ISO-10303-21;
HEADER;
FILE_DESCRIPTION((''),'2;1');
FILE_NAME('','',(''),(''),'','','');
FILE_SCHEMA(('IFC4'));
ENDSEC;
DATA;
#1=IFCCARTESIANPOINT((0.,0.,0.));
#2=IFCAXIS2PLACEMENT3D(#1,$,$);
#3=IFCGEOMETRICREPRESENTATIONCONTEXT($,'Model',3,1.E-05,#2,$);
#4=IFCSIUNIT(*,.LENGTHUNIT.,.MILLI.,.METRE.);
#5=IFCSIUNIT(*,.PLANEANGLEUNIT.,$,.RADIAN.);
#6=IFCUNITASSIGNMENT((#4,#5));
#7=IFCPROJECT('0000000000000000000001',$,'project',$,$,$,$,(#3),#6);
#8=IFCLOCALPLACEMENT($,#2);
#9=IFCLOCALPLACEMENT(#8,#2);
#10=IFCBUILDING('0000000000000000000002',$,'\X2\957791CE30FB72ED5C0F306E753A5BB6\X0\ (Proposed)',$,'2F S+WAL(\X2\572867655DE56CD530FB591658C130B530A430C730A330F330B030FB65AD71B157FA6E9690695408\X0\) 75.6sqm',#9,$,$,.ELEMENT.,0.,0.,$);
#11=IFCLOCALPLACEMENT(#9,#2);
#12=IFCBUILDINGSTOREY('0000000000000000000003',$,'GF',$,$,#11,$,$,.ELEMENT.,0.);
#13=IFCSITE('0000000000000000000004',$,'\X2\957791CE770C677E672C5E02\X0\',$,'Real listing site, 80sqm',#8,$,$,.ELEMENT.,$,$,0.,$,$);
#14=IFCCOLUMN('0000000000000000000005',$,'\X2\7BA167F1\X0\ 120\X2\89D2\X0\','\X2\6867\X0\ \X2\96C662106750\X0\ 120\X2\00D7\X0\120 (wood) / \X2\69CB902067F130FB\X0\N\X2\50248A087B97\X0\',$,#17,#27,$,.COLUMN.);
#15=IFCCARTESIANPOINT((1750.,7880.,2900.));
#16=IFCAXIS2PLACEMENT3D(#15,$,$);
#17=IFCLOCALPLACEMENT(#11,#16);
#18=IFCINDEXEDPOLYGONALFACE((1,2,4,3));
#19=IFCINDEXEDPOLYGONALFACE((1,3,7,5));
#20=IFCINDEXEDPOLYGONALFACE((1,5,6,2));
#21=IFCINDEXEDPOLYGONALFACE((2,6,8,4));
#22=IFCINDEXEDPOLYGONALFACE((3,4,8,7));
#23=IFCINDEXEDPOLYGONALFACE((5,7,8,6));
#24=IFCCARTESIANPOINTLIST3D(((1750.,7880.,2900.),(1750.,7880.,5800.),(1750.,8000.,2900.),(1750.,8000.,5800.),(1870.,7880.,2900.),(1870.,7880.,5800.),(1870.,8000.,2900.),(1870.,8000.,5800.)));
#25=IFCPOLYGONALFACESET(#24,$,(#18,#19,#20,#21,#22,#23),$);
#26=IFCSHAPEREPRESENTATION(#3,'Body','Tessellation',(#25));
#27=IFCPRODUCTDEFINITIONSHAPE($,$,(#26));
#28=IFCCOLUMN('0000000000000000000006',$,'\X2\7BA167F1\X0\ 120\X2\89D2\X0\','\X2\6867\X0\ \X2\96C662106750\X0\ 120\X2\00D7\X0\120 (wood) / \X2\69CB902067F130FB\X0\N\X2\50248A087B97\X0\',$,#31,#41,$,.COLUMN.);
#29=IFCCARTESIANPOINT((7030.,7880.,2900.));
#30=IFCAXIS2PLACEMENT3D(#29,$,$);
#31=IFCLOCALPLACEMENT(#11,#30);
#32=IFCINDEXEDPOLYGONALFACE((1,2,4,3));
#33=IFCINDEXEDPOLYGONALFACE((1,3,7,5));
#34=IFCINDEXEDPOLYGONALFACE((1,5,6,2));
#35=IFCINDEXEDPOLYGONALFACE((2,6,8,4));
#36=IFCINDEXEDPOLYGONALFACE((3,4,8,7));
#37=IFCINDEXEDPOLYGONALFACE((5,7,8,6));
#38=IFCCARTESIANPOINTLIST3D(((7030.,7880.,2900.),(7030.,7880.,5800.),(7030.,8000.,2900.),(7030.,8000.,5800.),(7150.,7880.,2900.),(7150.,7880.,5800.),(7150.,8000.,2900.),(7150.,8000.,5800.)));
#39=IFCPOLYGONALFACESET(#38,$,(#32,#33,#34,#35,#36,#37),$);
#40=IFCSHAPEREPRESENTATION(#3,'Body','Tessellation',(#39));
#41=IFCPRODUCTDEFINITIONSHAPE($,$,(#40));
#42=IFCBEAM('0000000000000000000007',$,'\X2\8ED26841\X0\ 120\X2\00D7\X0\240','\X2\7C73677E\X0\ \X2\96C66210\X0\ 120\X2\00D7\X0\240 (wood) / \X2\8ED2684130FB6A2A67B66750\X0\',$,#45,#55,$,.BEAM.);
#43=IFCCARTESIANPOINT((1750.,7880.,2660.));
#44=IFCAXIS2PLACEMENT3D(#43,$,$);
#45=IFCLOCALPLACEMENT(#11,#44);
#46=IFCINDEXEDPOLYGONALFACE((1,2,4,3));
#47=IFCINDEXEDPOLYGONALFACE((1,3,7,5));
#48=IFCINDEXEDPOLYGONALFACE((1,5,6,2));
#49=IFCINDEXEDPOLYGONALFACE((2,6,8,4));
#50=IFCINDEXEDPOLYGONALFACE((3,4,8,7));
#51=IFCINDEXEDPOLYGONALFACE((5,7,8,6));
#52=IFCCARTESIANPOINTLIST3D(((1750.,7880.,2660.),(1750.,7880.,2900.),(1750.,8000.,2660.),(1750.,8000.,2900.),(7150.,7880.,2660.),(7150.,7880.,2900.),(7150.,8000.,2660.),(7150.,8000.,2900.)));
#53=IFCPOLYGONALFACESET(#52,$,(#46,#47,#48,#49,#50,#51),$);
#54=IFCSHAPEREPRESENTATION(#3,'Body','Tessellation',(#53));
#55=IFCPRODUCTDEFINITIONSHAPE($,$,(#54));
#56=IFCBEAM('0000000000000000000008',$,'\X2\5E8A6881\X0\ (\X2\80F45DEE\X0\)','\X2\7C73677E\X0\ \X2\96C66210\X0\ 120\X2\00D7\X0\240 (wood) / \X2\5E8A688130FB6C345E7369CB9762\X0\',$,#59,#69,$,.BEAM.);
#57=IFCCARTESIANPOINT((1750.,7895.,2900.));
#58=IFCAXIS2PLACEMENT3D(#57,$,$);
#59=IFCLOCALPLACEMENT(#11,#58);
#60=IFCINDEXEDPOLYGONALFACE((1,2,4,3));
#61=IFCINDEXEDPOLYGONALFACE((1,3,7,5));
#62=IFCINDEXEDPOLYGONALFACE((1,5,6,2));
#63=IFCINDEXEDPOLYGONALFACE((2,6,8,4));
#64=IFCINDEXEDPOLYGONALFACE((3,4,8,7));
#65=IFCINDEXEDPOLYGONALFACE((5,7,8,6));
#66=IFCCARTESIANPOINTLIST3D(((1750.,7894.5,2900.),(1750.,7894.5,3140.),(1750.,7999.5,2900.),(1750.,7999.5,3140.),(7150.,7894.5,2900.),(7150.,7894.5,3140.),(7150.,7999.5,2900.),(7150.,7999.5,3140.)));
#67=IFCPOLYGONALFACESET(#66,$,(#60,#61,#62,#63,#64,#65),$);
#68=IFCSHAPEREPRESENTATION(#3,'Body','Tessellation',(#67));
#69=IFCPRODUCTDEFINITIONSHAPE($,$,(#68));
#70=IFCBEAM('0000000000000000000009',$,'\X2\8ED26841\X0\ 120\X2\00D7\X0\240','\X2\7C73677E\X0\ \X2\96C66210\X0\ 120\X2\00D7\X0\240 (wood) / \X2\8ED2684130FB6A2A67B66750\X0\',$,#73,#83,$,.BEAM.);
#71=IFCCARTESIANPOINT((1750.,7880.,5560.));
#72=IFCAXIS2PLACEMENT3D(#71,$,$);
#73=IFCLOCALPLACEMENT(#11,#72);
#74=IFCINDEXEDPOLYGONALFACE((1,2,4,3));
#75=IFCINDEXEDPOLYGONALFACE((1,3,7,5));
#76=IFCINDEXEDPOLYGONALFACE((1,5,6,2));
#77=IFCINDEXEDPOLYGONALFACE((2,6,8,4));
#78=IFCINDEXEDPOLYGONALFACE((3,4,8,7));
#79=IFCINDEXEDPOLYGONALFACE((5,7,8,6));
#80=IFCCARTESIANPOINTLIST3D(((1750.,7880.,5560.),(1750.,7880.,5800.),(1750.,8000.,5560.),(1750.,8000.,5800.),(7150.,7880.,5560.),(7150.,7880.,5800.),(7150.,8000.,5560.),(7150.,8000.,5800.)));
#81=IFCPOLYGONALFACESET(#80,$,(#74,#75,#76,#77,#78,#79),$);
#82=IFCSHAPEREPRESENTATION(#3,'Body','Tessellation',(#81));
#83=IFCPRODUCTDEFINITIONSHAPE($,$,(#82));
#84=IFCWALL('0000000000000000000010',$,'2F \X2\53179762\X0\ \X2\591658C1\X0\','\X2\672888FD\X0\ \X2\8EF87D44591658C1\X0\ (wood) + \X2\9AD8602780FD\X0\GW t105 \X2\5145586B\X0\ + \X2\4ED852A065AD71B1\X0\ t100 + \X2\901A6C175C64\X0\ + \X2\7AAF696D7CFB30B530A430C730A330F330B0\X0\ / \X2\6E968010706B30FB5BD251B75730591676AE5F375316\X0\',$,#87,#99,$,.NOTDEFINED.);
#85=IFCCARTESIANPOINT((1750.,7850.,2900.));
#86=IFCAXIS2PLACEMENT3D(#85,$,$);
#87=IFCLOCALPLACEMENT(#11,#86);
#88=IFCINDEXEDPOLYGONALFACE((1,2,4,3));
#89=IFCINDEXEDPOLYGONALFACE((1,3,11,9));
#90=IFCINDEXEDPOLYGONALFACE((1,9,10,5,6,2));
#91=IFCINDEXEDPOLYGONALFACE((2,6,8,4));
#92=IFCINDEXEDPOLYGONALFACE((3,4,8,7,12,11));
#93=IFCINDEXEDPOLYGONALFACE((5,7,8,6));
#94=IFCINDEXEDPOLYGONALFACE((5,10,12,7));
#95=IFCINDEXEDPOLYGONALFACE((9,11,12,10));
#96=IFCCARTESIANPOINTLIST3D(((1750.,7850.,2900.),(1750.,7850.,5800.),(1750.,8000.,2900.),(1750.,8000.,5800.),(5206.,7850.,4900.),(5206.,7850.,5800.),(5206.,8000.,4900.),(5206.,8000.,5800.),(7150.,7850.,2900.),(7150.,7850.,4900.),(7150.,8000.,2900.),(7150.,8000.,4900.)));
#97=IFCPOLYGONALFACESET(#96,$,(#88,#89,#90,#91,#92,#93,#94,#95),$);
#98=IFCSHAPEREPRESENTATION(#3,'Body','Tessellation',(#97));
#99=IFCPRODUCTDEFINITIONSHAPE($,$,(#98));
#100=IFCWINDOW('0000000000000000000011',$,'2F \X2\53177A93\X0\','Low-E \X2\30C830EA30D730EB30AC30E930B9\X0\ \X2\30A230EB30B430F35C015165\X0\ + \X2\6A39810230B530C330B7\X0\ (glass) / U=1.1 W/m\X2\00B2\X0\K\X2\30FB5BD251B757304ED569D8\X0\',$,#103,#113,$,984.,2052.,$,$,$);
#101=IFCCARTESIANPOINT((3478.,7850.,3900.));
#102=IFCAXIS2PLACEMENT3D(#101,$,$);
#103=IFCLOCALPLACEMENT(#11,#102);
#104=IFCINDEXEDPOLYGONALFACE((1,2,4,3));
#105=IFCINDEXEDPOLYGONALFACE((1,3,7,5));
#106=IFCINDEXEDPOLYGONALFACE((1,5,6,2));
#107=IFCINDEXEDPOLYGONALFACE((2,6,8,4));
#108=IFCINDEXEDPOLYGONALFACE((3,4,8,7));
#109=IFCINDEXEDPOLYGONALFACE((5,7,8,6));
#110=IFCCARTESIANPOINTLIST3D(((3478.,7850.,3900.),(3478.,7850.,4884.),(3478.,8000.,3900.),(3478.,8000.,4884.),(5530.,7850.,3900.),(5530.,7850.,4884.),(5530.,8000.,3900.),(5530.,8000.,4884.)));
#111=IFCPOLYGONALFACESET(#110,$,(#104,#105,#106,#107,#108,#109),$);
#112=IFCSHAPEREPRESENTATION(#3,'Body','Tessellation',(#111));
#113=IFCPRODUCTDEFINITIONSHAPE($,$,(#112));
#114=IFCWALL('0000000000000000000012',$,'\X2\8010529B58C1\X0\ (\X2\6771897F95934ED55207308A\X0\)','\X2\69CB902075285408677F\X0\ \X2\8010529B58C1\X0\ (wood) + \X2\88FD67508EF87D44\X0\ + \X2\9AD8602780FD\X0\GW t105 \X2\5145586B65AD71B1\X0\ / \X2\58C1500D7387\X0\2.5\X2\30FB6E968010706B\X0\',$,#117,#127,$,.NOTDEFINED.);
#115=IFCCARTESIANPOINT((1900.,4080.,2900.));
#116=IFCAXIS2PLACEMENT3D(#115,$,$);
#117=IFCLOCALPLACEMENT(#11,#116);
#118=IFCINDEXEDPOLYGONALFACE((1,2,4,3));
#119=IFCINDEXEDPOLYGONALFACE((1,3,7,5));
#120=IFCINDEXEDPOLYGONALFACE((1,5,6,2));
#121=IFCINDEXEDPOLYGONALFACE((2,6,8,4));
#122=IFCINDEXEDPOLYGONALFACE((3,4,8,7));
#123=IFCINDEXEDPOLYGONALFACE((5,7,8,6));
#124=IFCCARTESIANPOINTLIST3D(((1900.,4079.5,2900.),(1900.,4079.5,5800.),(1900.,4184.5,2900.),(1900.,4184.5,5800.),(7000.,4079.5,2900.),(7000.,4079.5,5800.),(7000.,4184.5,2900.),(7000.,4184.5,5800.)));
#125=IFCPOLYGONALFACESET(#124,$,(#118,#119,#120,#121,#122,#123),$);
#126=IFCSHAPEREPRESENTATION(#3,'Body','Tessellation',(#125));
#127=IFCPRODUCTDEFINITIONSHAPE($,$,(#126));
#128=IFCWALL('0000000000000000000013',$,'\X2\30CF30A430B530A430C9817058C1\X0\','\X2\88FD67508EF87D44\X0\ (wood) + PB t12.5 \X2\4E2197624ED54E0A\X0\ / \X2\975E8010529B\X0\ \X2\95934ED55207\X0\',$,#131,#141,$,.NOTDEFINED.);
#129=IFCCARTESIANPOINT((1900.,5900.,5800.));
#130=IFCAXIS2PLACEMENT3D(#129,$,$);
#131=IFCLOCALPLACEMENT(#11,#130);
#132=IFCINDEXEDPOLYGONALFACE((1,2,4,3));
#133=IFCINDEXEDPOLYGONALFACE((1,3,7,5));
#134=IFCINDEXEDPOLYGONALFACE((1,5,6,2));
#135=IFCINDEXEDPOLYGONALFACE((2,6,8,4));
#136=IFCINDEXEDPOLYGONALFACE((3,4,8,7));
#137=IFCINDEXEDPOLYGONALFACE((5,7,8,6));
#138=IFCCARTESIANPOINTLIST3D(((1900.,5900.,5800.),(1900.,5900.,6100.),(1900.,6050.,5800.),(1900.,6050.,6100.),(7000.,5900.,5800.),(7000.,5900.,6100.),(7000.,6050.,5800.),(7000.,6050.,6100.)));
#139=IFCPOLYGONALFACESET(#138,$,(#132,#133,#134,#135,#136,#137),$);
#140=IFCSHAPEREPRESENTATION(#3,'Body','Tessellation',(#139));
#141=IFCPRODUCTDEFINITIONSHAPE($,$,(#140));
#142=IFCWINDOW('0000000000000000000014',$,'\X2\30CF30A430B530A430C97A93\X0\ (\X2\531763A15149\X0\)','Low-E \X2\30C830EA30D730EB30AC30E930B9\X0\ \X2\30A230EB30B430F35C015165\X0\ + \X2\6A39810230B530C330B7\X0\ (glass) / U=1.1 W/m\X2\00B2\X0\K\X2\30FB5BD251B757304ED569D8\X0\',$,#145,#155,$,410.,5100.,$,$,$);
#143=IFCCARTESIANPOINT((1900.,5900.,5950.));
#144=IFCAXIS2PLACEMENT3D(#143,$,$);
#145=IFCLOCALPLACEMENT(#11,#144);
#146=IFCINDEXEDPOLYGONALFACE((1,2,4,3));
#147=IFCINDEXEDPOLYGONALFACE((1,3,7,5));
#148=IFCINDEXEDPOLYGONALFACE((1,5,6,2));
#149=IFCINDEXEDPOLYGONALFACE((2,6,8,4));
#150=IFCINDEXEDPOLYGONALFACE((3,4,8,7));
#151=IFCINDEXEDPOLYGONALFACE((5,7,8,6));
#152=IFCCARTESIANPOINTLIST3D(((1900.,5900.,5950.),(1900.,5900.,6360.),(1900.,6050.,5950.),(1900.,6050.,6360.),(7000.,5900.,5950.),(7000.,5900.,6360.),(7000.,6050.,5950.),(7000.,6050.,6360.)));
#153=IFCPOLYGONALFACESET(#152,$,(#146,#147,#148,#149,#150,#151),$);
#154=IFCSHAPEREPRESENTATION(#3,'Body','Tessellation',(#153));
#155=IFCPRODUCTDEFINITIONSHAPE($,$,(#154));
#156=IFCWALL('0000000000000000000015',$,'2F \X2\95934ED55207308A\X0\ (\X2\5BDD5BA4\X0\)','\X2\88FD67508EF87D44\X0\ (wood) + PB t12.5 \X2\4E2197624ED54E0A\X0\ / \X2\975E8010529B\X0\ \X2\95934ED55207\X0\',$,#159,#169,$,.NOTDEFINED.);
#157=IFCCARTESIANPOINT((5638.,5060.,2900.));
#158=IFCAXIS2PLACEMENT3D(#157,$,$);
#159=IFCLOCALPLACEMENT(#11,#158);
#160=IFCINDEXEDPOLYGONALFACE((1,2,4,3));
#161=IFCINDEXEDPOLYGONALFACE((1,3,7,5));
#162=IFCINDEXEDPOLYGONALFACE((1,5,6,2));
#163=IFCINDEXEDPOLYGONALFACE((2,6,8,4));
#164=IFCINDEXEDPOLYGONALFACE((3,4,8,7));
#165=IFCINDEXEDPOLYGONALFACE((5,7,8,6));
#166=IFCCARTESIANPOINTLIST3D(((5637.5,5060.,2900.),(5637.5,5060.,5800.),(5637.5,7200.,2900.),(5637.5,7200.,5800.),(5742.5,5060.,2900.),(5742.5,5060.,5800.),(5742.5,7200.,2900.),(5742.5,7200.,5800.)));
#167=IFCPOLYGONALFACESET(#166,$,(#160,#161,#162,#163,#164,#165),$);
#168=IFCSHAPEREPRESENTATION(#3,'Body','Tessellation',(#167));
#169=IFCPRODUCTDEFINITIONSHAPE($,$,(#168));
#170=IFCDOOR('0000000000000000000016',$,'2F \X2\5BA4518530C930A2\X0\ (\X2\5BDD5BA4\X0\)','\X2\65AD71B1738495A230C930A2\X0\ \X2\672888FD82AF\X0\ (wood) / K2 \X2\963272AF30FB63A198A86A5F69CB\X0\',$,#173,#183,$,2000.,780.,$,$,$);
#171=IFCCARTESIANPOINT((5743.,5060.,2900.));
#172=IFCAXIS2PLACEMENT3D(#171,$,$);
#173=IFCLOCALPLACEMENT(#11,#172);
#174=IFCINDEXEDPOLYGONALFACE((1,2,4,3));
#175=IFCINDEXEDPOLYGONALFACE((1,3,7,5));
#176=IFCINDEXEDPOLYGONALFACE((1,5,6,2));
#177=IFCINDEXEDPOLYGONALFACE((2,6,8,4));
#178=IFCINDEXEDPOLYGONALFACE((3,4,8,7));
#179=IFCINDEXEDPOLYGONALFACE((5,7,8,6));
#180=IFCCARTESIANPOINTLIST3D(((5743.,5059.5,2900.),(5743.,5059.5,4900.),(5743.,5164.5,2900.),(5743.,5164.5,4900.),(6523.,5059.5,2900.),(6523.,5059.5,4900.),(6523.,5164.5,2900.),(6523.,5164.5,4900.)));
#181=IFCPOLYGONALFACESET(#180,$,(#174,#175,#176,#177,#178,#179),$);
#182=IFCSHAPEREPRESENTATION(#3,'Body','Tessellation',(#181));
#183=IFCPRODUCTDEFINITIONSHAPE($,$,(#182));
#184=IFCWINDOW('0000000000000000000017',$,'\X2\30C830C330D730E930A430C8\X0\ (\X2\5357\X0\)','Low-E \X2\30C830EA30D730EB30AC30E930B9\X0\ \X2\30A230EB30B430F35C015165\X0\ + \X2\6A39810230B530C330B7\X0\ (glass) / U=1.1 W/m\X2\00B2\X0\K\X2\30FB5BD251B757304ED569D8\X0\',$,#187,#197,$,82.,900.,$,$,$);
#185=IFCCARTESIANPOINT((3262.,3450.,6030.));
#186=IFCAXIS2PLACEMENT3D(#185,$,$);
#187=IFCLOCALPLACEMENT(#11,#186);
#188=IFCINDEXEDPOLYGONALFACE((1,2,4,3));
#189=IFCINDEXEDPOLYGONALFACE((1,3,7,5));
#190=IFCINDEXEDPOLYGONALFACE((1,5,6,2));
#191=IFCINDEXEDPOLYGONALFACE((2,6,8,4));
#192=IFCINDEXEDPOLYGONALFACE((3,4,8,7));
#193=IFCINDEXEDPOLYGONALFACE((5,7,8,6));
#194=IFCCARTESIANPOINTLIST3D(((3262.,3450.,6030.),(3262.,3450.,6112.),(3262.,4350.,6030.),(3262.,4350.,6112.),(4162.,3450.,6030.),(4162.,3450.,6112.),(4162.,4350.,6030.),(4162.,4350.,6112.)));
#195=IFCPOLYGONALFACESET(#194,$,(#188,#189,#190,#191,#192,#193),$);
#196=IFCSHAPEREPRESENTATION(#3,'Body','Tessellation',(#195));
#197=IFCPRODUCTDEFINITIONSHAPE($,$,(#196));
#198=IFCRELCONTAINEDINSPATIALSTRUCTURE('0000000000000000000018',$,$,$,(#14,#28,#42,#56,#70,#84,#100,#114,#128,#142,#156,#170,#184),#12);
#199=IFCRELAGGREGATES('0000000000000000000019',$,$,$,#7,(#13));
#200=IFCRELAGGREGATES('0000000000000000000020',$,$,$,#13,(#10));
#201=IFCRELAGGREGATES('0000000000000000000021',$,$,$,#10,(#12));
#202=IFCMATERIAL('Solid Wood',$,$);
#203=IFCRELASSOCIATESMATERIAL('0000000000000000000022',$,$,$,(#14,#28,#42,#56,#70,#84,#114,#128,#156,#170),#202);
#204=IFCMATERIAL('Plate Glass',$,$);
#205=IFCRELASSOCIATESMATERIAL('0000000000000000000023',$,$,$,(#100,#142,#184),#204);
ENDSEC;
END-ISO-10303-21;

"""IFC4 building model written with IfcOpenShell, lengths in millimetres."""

from ifc_helpers import new_model, si_unit, frame, frame_2d, origin, place, context, project, spatial, rectangle, extrude, material, element, fill, save


model = new_model("IFC4")

# Units and contexts
model_context = context("Model", 3, precision=1e-05, world=origin())
ifc_project = project(units=[si_unit("LENGTHUNIT", "METRE", prefix="MILLI"), si_unit("PLANEANGLEUNIT", "RADIAN")], contexts=[model_context])

# Site, building, storey
site_placement = place(None, origin())
site = spatial("IfcSite", under=ifc_project, at=site_placement, Name="長野県松本市", ObjectType="Real listing site, 80sqm", CompositionType="ELEMENT", RefElevation=0.0)
building_placement = place(site_placement, origin())
building = spatial("IfcBuilding", under=site, at=building_placement, Name="長野・狭小の町家 (Proposed)", ObjectType="2F S+WAL(在来工法・外壁サイディング・断熱基準適合) 75.6sqm", CompositionType="ELEMENT", ElevationOfRefHeight=0.0, ElevationOfTerrain=0.0)
storey_placement = place(building_placement, origin())
storey = spatial("IfcBuildingStorey", under=building, at=storey_placement, Name="GF", CompositionType="ELEMENT", Elevation=0.0)

# Columns
ifc_material_1 = material(Name="Solid Wood")
column_1_placement = place(storey_placement, frame((1750.0, 7880.0, 2900.0)))
element("IfcColumn", 1, at=column_1_placement, inside=storey, material=ifc_material_1, Name="管柱 120角", Description="桧 集成材 120×120 (wood) / 構造柱・N値計算", PredefinedType="COLUMN", context=model_context, shape_type="SweptSolid", body=[
    extrude(rectangle(XDim=120.0, YDim=120.0, at=frame_2d((60.0, 60.0))), frame((1750.0, 7880.0, 2900.0)), (0.0, 0.0, 1.0), 2900.0),
])
column_2_placement = place(storey_placement, frame((7030.0, 7880.0, 2900.0)))
element("IfcColumn", 2, at=column_2_placement, inside=storey, material=ifc_material_1, Name="管柱 120角", Description="桧 集成材 120×120 (wood) / 構造柱・N値計算", PredefinedType="COLUMN", context=model_context, shape_type="SweptSolid", body=[
    extrude(rectangle(XDim=120.0, YDim=120.0, at=frame_2d((60.0, 60.0))), frame((7030.0, 7880.0, 2900.0)), (0.0, 0.0, 1.0), 2900.0),
])

# Beams
beam_1_placement = place(storey_placement, frame((1750.0, 7880.0, 2660.0)))
element("IfcBeam", 3, at=beam_1_placement, inside=storey, material=ifc_material_1, Name="軒桁 120×240", Description="米松 集成 120×240 (wood) / 軒桁・横架材", PredefinedType="BEAM", context=model_context, shape_type="SweptSolid", body=[
    extrude(rectangle(XDim=5400.0, YDim=120.0, at=frame_2d((2700.0, 60.0))), frame((1750.0, 7880.0, 2660.0)), (0.0, 0.0, 1.0), 240.0),
])
beam_2_placement = place(storey_placement, frame((1750.0, 7895.0, 2900.0)))
element("IfcBeam", 4, at=beam_2_placement, inside=storey, material=ifc_material_1, Name="床梁 (胴差)", Description="米松 集成 120×240 (wood) / 床梁・水平構面", PredefinedType="BEAM", context=model_context, shape_type="SweptSolid", body=[
    extrude(rectangle(XDim=5400.0, YDim=105.0, at=frame_2d((2700.0, 52.0))), frame((1750.0, 7895.0, 2900.0)), (0.0, 0.0, 1.0), 240.0),
])
beam_3_placement = place(storey_placement, frame((1750.0, 7880.0, 5560.0)))
element("IfcBeam", 5, at=beam_3_placement, inside=storey, material=ifc_material_1, Name="軒桁 120×240", Description="米松 集成 120×240 (wood) / 軒桁・横架材", PredefinedType="BEAM", context=model_context, shape_type="SweptSolid", body=[
    extrude(rectangle(XDim=5400.0, YDim=120.0, at=frame_2d((2700.0, 60.0))), frame((1750.0, 7880.0, 5560.0)), (0.0, 0.0, 1.0), 240.0),
])

# Wall, opening, window
wall_1_placement = place(storey_placement, frame((1750.0, 7850.0, 2900.0)))
wall_1 = element("IfcWall", 6, at=wall_1_placement, inside=storey, material=ifc_material_1, Name="2F 北面 外壁", Description="木製 軸組外壁 (wood) + 高性能GW t105 充填 + 付加断熱 t100 + 通気層 + 窯業系サイディング / 準耐火・寒冷地外皮強化", PredefinedType="NOTDEFINED", context=model_context, shape_type="SweptSolid", body=[
    extrude(rectangle(XDim=5400.0, YDim=150.0, at=frame_2d((2700.0, 75.0))), frame((1750.0, 7850.0, 2900.0)), (0.0, 0.0, 1.0), 2900.0),
])
opening_1_placement = place(storey_placement, frame((3478.0, 7850.0, 3900.0)))
opening_1 = element("IfcOpeningElement", 7, at=opening_1_placement, cuts=wall_1, PredefinedType="NOTDEFINED", context=model_context, shape_type="SweptSolid", body=[
    extrude(rectangle(XDim=2052.0, YDim=150.0, at=frame_2d((1026.0, 75.0))), frame((3478.0, 7850.0, 3900.0)), (0.0, 0.0, 1.0), 984.0),
])
ifc_material_2 = material(Name="Plate Glass")
window_1_placement = place(storey_placement, frame((3478.0, 7850.0, 3900.0)))
window_1 = element("IfcWindow", 8, at=window_1_placement, inside=storey, material=ifc_material_2, Name="2F 北窓", Description="Low-E トリプルガラス アルゴン封入 + 樹脂サッシ (glass) / U=1.1 W/m²K・寒冷地仕様", OverallHeight=984.0, OverallWidth=2052.0, context=model_context, shape_type="SweptSolid", body=[
    extrude(rectangle(XDim=2052.0, YDim=150.0, at=frame_2d((1026.0, 75.0))), frame((3478.0, 7850.0, 3900.0)), (0.0, 0.0, 1.0), 984.0),
])
fill(opening_1, window_1)

# Wall
wall_2_placement = place(storey_placement, frame((1900.0, 4080.0, 2900.0)))
element("IfcWall", 9, at=wall_2_placement, inside=storey, material=ifc_material_1, Name="耐力壁 (東西間仕切り)", Description="構造用合板 耐力壁 (wood) + 製材軸組 + 高性能GW t105 充填断熱 / 壁倍率2.5・準耐火", PredefinedType="NOTDEFINED", context=model_context, shape_type="SweptSolid", body=[
    extrude(rectangle(XDim=5100.0, YDim=105.0, at=frame_2d((2550.0, 52.0))), frame((1900.0, 4080.0, 2900.0)), (0.0, 0.0, 1.0), 2900.0),
])

# Wall, opening, window
wall_3_placement = place(storey_placement, frame((1900.0, 5900.0, 5800.0)))
wall_3 = element("IfcWall", 10, at=wall_3_placement, inside=storey, material=ifc_material_1, Name="ハイサイド腰壁", Description="製材軸組 (wood) + PB t12.5 両面仕上 / 非耐力 間仕切", PredefinedType="NOTDEFINED", context=model_context, shape_type="SweptSolid", body=[
    extrude(rectangle(XDim=5100.0, YDim=150.0, at=frame_2d((2550.0, 75.0))), frame((1900.0, 5900.0, 5800.0)), (0.0, 0.0, 1.0), 700.0),
])
opening_2_placement = place(storey_placement, frame((1900.0, 5900.0, 5950.0)))
opening_2 = element("IfcOpeningElement", 11, at=opening_2_placement, cuts=wall_3, PredefinedType="NOTDEFINED", context=model_context, shape_type="SweptSolid", body=[
    extrude(rectangle(XDim=5100.0, YDim=150.0, at=frame_2d((2550.0, 75.0))), frame((1900.0, 5900.0, 5950.0)), (0.0, 0.0, 1.0), 410.0),
])
window_2_placement = place(storey_placement, frame((1900.0, 5900.0, 5950.0)))
window_2 = element("IfcWindow", 12, at=window_2_placement, inside=storey, material=ifc_material_2, Name="ハイサイド窓 (北採光)", Description="Low-E トリプルガラス アルゴン封入 + 樹脂サッシ (glass) / U=1.1 W/m²K・寒冷地仕様", OverallHeight=410.0, OverallWidth=5100.0, context=model_context, shape_type="SweptSolid", body=[
    extrude(rectangle(XDim=5100.0, YDim=150.0, at=frame_2d((2550.0, 75.0))), frame((1900.0, 5900.0, 5950.0)), (0.0, 0.0, 1.0), 410.0),
])
fill(opening_2, window_2)

# Wall
wall_4_placement = place(storey_placement, frame((5638.0, 5060.0, 2900.0)))
element("IfcWall", 13, at=wall_4_placement, inside=storey, material=ifc_material_1, Name="2F 間仕切り (寝室)", Description="製材軸組 (wood) + PB t12.5 両面仕上 / 非耐力 間仕切", PredefinedType="NOTDEFINED", context=model_context, shape_type="SweptSolid", body=[
    extrude(rectangle(XDim=105.0, YDim=2140.0, at=frame_2d((52.0, 1070.0))), frame((5638.0, 5060.0, 2900.0)), (0.0, 0.0, 1.0), 2900.0),
])

# Door
door_placement = place(storey_placement, frame((5743.0, 5060.0, 2900.0)))
element("IfcDoor", 14, at=door_placement, inside=storey, material=ifc_material_1, Name="2F 室内ドア (寝室)", Description="断熱玄関ドア 木製芯 (wood) / K2 防犯・採風機構", OverallHeight=2000.0, OverallWidth=780.0, context=model_context, shape_type="SweptSolid", body=[
    extrude(rectangle(XDim=780.0, YDim=105.0, at=frame_2d((390.0, 52.0))), frame((5743.0, 5060.0, 2900.0)), (0.0, 0.0, 1.0), 2000.0),
])

# Window
window_3_placement = place(storey_placement, frame((3262.0, 3450.0, 6030.0)))
element("IfcWindow", 15, at=window_3_placement, inside=storey, material=ifc_material_2, Name="トップライト (南)", Description="Low-E トリプルガラス アルゴン封入 + 樹脂サッシ (glass) / U=1.1 W/m²K・寒冷地仕様", OverallHeight=82.0, OverallWidth=900.0, context=model_context, shape_type="SweptSolid", body=[
    extrude(rectangle(XDim=900.0, YDim=900.0, at=frame_2d((450.0, 450.0))), frame((3262.0, 3450.0, 6030.0)), (0.0, 0.0, 1.0), 82.0),
])

save(model, "model.ifc")
